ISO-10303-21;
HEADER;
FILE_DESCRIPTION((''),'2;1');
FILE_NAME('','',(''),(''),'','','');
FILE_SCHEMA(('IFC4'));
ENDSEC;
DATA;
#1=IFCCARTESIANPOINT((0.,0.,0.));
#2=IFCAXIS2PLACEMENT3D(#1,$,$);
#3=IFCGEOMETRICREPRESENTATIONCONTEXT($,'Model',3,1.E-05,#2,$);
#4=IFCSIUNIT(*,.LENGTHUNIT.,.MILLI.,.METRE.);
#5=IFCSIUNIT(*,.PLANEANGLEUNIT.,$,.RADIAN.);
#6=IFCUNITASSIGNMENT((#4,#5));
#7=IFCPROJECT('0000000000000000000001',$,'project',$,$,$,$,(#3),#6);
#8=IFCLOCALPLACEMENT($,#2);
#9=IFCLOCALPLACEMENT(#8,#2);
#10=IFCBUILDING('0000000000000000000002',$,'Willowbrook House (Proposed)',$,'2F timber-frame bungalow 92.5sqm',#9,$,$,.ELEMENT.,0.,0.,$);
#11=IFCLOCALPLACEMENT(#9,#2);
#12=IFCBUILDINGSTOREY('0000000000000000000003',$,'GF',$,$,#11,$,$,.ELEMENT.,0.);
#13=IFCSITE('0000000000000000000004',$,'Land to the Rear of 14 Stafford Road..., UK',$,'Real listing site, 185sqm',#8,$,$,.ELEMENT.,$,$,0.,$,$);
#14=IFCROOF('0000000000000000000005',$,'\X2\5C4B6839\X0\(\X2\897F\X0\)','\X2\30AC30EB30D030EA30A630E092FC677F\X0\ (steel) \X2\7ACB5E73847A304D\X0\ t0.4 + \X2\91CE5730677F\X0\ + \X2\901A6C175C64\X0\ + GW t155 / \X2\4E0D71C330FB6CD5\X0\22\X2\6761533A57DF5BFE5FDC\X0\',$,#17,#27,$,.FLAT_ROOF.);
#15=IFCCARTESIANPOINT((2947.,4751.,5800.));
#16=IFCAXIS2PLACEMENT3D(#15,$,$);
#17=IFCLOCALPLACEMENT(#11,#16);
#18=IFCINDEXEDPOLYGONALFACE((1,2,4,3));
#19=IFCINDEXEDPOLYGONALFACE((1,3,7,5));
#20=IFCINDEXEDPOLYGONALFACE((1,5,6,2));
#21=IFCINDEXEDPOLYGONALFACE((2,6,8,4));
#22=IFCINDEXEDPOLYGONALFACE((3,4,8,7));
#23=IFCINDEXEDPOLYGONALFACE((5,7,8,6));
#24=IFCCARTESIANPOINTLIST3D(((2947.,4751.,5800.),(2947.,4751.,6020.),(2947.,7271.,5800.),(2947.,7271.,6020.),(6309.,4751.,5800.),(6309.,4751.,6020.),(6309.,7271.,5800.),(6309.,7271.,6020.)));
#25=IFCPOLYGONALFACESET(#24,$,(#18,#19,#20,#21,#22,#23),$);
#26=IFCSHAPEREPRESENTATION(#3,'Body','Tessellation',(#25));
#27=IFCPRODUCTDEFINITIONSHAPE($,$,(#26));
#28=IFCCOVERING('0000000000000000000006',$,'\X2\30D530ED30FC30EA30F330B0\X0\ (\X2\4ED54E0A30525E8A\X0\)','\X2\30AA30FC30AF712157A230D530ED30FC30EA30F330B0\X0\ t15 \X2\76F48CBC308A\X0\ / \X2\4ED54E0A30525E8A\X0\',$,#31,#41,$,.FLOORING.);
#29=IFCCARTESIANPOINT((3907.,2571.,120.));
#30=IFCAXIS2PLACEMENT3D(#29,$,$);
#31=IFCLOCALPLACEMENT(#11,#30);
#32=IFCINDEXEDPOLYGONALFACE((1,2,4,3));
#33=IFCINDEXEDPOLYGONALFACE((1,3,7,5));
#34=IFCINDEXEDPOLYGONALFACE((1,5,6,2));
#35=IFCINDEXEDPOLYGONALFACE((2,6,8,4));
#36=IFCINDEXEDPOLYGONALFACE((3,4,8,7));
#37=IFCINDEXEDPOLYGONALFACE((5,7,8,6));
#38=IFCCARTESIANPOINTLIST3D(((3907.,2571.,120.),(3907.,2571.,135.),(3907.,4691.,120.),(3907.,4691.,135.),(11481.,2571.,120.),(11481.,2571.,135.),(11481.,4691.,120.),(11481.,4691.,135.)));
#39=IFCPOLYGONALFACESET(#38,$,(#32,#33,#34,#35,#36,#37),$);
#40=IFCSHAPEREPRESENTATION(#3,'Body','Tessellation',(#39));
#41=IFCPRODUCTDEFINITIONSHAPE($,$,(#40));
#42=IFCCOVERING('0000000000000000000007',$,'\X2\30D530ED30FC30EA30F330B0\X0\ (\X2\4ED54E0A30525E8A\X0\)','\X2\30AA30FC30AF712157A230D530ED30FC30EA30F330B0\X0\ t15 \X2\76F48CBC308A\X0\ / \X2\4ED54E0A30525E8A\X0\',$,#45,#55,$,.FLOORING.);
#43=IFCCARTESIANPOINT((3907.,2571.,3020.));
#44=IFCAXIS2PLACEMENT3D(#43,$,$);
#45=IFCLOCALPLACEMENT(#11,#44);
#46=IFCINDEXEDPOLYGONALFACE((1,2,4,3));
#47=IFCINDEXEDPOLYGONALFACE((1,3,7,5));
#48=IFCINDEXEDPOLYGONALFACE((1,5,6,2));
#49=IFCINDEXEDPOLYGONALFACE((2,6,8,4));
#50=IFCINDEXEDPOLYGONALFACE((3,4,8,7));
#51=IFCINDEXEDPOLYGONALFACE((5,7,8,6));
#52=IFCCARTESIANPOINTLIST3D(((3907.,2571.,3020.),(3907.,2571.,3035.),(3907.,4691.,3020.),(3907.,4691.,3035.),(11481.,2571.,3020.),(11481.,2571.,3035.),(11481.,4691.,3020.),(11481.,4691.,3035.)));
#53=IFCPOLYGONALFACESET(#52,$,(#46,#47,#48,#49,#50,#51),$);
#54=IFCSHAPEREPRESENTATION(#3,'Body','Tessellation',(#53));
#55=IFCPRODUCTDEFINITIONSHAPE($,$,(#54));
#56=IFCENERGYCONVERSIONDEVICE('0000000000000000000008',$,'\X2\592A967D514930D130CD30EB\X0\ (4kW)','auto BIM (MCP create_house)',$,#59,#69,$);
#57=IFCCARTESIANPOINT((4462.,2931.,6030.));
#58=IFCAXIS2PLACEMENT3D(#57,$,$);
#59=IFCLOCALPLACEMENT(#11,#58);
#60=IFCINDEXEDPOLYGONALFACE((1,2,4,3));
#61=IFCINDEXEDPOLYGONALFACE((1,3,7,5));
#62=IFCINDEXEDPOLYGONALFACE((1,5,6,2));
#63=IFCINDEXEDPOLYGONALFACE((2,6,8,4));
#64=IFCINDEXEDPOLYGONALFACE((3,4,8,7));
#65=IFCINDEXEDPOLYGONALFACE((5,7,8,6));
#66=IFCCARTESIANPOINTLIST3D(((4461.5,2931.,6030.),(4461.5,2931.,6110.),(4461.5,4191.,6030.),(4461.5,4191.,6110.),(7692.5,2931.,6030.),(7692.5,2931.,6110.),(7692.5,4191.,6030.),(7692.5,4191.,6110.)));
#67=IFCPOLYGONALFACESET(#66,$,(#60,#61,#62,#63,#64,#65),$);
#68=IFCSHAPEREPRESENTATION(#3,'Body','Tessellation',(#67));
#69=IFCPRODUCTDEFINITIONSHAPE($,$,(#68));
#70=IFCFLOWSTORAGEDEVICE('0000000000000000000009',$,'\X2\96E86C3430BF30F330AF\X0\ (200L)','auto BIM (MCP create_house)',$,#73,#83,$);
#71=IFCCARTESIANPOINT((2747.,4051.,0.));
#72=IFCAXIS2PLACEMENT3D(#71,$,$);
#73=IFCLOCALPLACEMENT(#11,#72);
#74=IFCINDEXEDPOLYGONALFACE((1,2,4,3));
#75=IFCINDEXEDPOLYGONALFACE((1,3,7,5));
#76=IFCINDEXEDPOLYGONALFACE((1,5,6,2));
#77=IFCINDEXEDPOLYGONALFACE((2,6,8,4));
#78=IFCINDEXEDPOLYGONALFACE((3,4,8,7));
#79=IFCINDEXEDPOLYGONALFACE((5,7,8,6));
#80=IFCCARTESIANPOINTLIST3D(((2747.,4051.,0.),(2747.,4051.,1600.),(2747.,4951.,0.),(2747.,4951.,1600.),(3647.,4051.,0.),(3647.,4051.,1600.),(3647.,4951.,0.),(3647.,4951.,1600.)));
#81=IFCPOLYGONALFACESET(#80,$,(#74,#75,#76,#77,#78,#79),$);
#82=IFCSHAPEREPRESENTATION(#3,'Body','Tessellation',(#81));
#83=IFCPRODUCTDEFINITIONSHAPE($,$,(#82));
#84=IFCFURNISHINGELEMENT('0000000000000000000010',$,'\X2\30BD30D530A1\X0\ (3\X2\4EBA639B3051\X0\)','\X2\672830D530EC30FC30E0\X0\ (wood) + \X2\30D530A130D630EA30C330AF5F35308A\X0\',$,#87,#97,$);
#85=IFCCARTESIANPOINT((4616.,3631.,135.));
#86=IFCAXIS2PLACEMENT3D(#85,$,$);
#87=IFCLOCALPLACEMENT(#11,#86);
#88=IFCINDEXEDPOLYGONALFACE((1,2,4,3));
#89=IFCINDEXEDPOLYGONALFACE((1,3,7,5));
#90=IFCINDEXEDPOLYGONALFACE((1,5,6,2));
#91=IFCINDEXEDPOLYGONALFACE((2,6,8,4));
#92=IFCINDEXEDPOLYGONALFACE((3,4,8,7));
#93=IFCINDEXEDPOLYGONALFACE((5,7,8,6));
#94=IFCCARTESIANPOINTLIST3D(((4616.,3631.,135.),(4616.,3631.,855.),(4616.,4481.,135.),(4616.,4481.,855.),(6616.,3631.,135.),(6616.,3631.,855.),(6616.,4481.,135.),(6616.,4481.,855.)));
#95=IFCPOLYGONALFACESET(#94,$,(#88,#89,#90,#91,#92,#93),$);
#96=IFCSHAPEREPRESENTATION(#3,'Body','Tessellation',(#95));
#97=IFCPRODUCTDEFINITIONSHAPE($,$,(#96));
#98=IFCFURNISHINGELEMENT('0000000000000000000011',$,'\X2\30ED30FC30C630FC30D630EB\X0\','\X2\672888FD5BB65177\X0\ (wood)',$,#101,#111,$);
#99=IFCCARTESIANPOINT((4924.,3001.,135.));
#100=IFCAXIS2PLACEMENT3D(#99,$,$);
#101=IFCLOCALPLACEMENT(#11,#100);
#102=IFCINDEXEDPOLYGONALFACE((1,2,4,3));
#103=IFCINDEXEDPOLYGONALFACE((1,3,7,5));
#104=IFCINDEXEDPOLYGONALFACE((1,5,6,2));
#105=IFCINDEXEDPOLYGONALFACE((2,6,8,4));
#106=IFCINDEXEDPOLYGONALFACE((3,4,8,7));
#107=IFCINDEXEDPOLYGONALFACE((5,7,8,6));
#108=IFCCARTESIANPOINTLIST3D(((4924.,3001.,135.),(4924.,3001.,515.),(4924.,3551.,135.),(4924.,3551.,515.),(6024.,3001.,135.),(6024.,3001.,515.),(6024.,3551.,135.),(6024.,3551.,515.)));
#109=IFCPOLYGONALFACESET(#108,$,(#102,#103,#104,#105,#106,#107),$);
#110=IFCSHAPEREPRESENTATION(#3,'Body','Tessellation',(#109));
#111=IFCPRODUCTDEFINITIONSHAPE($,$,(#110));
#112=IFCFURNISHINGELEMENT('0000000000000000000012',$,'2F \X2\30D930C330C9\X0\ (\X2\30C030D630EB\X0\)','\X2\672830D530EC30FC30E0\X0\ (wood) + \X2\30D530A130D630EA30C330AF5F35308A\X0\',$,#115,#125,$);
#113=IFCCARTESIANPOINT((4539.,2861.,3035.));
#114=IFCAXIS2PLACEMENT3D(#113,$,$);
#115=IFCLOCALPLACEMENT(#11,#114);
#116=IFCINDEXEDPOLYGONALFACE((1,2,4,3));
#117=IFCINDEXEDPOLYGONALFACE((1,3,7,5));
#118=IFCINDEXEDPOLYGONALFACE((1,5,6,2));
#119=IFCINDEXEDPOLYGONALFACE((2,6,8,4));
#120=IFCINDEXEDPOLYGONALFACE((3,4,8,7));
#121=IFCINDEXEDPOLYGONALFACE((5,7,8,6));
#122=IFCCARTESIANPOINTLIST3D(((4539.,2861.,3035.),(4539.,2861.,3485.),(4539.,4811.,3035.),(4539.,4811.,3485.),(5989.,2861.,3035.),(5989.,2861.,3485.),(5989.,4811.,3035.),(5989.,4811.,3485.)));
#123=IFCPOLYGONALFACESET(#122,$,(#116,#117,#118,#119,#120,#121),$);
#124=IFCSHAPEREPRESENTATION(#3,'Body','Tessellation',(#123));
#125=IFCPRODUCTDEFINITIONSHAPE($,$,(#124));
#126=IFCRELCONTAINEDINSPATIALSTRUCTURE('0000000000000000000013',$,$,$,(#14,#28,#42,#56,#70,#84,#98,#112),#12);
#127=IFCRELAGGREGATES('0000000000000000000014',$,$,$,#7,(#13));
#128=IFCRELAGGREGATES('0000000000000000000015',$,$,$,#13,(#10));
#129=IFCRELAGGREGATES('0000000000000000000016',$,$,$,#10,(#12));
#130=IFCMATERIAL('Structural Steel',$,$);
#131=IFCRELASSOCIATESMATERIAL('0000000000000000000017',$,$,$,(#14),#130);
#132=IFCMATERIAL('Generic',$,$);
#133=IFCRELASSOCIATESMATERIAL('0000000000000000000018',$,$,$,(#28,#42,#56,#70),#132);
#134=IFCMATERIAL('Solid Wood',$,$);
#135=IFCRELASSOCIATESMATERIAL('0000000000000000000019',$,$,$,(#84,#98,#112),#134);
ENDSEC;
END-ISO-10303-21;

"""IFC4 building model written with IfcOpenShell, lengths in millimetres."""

from ifc_helpers import new_model, si_unit, frame, frame_2d, origin, place, context, project, spatial, rectangle, extrude, material, element, save


model = new_model("IFC4")

# Units and contexts
model_context = context("Model", 3, precision=1e-05, world=origin())
ifc_project = project(units=[si_unit("LENGTHUNIT", "METRE", prefix="MILLI"), si_unit("PLANEANGLEUNIT", "RADIAN")], contexts=[model_context])

# Site, building, storey
site_placement = place(None, origin())
site = spatial("IfcSite", under=ifc_project, at=site_placement, Name="Land to the Rear of 14 Stafford Road..., UK", ObjectType="Real listing site, 185sqm", CompositionType="ELEMENT", RefElevation=0.0)
building_placement = place(site_placement, origin())
building = spatial("IfcBuilding", under=site, at=building_placement, Name="Willowbrook House (Proposed)", ObjectType="2F timber-frame bungalow 92.5sqm", CompositionType="ELEMENT", ElevationOfRefHeight=0.0, ElevationOfTerrain=0.0)
storey_placement = place(building_placement, origin())
storey = spatial("IfcBuildingStorey", under=building, at=storey_placement, Name="GF", CompositionType="ELEMENT", Elevation=0.0)

# Shared definitions
ifc_material_1 = material(Name="Solid Wood")

# Roof
ifc_material_2 = material(Name="Structural Steel")
roof_1_placement = place(storey_placement, frame((2947.0, 4751.0, 5800.0)))
element("IfcRoof", 1, at=roof_1_placement, inside=storey, material=ifc_material_2, Name="屋根(西)", Description="ガルバリウム鋼板 (steel) 立平葺き t0.4 + 野地板 + 通気層 + GW t155 / 不燃・法22条区域対応", PredefinedType="FLAT_ROOF", context=model_context, shape_type="SweptSolid", body=[
    extrude(rectangle(XDim=3362.0, YDim=2520.0, at=frame_2d((1681.0, 1260.0))), frame((2947.0, 4751.0, 5800.0)), (0.0, 0.0, 1.0), 220.0),
])

# Coverings
ifc_material_3 = material(Name="Generic")
covering_1_placement = place(storey_placement, frame((3907.0, 2571.0, 120.0)))
element("IfcCovering", 2, at=covering_1_placement, inside=storey, material=ifc_material_3, Name="フローリング (仕上げ床)", Description="オーク無垢フローリング t15 直貼り / 仕上げ床", PredefinedType="FLOORING", context=model_context, shape_type="SweptSolid", body=[
    extrude(rectangle(XDim=7574.0, YDim=2120.0, at=frame_2d((3787.0, 1060.0))), frame((3907.0, 2571.0, 120.0)), (0.0, 0.0, 1.0), 15.0),
])
covering_2_placement = place(storey_placement, frame((3907.0, 2571.0, 3020.0)))
element("IfcCovering", 3, at=covering_2_placement, inside=storey, material=ifc_material_3, Name="フローリング (仕上げ床)", Description="オーク無垢フローリング t15 直貼り / 仕上げ床", PredefinedType="FLOORING", context=model_context, shape_type="SweptSolid", body=[
    extrude(rectangle(XDim=7574.0, YDim=2120.0, at=frame_2d((3787.0, 1060.0))), frame((3907.0, 2571.0, 3020.0)), (0.0, 0.0, 1.0), 15.0),
])

# Energy conversion device
energy_conversion_device_placement = place(storey_placement, frame((4462.0, 2931.0, 6030.0)))
element("IfcEnergyConversionDevice", 4, at=energy_conversion_device_placement, inside=storey, material=ifc_material_3, Name="太陽光パネル (4kW)", Description="auto BIM (MCP create_house)", context=model_context, shape_type="SweptSolid", body=[
    extrude(rectangle(XDim=3231.0, YDim=1260.0, at=frame_2d((1615.0, 630.0))), frame((4462.0, 2931.0, 6030.0)), (0.0, 0.0, 1.0), 80.0),
])

# Flow storage device
flow_storage_device_placement = place(storey_placement, frame((2747.0, 4051.0, 0.0)))
element("IfcFlowStorageDevice", 5, at=flow_storage_device_placement, inside=storey, material=ifc_material_3, Name="雨水タンク (200L)", Description="auto BIM (MCP create_house)", context=model_context, shape_type="SweptSolid", body=[
    extrude(rectangle(XDim=900.0, YDim=900.0, at=frame_2d((450.0, 450.0))), frame((2747.0, 4051.0, 0.0)), (0.0, 0.0, 1.0), 1600.0),
])

# Furnishing elements
furnishing_1_placement = place(storey_placement, frame((4616.0, 3631.0, 135.0)))
element("IfcFurnishingElement", 6, at=furnishing_1_placement, inside=storey, material=ifc_material_1, Name="ソファ (3人掛け)", Description="木フレーム (wood) + ファブリック張り", context=model_context, shape_type="SweptSolid", body=[
    extrude(rectangle(XDim=2000.0, YDim=850.0, at=frame_2d((1000.0, 425.0))), frame((4616.0, 3631.0, 135.0)), (0.0, 0.0, 1.0), 720.0),
])
furnishing_2_placement = place(storey_placement, frame((4924.0, 3001.0, 135.0)))
element("IfcFurnishingElement", 7, at=furnishing_2_placement, inside=storey, material=ifc_material_1, Name="ローテーブル", Description="木製家具 (wood)", context=model_context, shape_type="SweptSolid", body=[
    extrude(rectangle(XDim=1100.0, YDim=550.0, at=frame_2d((550.0, 275.0))), frame((4924.0, 3001.0, 135.0)), (0.0, 0.0, 1.0), 380.0),
])
furnishing_3_placement = place(storey_placement, frame((4539.0, 2861.0, 3035.0)))
element("IfcFurnishingElement", 8, at=furnishing_3_placement, inside=storey, material=ifc_material_1, Name="2F ベッド (ダブル)", Description="木フレーム (wood) + ファブリック張り", context=model_context, shape_type="SweptSolid", body=[
    extrude(rectangle(XDim=1450.0, YDim=1950.0, at=frame_2d((725.0, 975.0))), frame((4539.0, 2861.0, 3035.0)), (0.0, 0.0, 1.0), 450.0),
])

save(model, "model.ifc")
